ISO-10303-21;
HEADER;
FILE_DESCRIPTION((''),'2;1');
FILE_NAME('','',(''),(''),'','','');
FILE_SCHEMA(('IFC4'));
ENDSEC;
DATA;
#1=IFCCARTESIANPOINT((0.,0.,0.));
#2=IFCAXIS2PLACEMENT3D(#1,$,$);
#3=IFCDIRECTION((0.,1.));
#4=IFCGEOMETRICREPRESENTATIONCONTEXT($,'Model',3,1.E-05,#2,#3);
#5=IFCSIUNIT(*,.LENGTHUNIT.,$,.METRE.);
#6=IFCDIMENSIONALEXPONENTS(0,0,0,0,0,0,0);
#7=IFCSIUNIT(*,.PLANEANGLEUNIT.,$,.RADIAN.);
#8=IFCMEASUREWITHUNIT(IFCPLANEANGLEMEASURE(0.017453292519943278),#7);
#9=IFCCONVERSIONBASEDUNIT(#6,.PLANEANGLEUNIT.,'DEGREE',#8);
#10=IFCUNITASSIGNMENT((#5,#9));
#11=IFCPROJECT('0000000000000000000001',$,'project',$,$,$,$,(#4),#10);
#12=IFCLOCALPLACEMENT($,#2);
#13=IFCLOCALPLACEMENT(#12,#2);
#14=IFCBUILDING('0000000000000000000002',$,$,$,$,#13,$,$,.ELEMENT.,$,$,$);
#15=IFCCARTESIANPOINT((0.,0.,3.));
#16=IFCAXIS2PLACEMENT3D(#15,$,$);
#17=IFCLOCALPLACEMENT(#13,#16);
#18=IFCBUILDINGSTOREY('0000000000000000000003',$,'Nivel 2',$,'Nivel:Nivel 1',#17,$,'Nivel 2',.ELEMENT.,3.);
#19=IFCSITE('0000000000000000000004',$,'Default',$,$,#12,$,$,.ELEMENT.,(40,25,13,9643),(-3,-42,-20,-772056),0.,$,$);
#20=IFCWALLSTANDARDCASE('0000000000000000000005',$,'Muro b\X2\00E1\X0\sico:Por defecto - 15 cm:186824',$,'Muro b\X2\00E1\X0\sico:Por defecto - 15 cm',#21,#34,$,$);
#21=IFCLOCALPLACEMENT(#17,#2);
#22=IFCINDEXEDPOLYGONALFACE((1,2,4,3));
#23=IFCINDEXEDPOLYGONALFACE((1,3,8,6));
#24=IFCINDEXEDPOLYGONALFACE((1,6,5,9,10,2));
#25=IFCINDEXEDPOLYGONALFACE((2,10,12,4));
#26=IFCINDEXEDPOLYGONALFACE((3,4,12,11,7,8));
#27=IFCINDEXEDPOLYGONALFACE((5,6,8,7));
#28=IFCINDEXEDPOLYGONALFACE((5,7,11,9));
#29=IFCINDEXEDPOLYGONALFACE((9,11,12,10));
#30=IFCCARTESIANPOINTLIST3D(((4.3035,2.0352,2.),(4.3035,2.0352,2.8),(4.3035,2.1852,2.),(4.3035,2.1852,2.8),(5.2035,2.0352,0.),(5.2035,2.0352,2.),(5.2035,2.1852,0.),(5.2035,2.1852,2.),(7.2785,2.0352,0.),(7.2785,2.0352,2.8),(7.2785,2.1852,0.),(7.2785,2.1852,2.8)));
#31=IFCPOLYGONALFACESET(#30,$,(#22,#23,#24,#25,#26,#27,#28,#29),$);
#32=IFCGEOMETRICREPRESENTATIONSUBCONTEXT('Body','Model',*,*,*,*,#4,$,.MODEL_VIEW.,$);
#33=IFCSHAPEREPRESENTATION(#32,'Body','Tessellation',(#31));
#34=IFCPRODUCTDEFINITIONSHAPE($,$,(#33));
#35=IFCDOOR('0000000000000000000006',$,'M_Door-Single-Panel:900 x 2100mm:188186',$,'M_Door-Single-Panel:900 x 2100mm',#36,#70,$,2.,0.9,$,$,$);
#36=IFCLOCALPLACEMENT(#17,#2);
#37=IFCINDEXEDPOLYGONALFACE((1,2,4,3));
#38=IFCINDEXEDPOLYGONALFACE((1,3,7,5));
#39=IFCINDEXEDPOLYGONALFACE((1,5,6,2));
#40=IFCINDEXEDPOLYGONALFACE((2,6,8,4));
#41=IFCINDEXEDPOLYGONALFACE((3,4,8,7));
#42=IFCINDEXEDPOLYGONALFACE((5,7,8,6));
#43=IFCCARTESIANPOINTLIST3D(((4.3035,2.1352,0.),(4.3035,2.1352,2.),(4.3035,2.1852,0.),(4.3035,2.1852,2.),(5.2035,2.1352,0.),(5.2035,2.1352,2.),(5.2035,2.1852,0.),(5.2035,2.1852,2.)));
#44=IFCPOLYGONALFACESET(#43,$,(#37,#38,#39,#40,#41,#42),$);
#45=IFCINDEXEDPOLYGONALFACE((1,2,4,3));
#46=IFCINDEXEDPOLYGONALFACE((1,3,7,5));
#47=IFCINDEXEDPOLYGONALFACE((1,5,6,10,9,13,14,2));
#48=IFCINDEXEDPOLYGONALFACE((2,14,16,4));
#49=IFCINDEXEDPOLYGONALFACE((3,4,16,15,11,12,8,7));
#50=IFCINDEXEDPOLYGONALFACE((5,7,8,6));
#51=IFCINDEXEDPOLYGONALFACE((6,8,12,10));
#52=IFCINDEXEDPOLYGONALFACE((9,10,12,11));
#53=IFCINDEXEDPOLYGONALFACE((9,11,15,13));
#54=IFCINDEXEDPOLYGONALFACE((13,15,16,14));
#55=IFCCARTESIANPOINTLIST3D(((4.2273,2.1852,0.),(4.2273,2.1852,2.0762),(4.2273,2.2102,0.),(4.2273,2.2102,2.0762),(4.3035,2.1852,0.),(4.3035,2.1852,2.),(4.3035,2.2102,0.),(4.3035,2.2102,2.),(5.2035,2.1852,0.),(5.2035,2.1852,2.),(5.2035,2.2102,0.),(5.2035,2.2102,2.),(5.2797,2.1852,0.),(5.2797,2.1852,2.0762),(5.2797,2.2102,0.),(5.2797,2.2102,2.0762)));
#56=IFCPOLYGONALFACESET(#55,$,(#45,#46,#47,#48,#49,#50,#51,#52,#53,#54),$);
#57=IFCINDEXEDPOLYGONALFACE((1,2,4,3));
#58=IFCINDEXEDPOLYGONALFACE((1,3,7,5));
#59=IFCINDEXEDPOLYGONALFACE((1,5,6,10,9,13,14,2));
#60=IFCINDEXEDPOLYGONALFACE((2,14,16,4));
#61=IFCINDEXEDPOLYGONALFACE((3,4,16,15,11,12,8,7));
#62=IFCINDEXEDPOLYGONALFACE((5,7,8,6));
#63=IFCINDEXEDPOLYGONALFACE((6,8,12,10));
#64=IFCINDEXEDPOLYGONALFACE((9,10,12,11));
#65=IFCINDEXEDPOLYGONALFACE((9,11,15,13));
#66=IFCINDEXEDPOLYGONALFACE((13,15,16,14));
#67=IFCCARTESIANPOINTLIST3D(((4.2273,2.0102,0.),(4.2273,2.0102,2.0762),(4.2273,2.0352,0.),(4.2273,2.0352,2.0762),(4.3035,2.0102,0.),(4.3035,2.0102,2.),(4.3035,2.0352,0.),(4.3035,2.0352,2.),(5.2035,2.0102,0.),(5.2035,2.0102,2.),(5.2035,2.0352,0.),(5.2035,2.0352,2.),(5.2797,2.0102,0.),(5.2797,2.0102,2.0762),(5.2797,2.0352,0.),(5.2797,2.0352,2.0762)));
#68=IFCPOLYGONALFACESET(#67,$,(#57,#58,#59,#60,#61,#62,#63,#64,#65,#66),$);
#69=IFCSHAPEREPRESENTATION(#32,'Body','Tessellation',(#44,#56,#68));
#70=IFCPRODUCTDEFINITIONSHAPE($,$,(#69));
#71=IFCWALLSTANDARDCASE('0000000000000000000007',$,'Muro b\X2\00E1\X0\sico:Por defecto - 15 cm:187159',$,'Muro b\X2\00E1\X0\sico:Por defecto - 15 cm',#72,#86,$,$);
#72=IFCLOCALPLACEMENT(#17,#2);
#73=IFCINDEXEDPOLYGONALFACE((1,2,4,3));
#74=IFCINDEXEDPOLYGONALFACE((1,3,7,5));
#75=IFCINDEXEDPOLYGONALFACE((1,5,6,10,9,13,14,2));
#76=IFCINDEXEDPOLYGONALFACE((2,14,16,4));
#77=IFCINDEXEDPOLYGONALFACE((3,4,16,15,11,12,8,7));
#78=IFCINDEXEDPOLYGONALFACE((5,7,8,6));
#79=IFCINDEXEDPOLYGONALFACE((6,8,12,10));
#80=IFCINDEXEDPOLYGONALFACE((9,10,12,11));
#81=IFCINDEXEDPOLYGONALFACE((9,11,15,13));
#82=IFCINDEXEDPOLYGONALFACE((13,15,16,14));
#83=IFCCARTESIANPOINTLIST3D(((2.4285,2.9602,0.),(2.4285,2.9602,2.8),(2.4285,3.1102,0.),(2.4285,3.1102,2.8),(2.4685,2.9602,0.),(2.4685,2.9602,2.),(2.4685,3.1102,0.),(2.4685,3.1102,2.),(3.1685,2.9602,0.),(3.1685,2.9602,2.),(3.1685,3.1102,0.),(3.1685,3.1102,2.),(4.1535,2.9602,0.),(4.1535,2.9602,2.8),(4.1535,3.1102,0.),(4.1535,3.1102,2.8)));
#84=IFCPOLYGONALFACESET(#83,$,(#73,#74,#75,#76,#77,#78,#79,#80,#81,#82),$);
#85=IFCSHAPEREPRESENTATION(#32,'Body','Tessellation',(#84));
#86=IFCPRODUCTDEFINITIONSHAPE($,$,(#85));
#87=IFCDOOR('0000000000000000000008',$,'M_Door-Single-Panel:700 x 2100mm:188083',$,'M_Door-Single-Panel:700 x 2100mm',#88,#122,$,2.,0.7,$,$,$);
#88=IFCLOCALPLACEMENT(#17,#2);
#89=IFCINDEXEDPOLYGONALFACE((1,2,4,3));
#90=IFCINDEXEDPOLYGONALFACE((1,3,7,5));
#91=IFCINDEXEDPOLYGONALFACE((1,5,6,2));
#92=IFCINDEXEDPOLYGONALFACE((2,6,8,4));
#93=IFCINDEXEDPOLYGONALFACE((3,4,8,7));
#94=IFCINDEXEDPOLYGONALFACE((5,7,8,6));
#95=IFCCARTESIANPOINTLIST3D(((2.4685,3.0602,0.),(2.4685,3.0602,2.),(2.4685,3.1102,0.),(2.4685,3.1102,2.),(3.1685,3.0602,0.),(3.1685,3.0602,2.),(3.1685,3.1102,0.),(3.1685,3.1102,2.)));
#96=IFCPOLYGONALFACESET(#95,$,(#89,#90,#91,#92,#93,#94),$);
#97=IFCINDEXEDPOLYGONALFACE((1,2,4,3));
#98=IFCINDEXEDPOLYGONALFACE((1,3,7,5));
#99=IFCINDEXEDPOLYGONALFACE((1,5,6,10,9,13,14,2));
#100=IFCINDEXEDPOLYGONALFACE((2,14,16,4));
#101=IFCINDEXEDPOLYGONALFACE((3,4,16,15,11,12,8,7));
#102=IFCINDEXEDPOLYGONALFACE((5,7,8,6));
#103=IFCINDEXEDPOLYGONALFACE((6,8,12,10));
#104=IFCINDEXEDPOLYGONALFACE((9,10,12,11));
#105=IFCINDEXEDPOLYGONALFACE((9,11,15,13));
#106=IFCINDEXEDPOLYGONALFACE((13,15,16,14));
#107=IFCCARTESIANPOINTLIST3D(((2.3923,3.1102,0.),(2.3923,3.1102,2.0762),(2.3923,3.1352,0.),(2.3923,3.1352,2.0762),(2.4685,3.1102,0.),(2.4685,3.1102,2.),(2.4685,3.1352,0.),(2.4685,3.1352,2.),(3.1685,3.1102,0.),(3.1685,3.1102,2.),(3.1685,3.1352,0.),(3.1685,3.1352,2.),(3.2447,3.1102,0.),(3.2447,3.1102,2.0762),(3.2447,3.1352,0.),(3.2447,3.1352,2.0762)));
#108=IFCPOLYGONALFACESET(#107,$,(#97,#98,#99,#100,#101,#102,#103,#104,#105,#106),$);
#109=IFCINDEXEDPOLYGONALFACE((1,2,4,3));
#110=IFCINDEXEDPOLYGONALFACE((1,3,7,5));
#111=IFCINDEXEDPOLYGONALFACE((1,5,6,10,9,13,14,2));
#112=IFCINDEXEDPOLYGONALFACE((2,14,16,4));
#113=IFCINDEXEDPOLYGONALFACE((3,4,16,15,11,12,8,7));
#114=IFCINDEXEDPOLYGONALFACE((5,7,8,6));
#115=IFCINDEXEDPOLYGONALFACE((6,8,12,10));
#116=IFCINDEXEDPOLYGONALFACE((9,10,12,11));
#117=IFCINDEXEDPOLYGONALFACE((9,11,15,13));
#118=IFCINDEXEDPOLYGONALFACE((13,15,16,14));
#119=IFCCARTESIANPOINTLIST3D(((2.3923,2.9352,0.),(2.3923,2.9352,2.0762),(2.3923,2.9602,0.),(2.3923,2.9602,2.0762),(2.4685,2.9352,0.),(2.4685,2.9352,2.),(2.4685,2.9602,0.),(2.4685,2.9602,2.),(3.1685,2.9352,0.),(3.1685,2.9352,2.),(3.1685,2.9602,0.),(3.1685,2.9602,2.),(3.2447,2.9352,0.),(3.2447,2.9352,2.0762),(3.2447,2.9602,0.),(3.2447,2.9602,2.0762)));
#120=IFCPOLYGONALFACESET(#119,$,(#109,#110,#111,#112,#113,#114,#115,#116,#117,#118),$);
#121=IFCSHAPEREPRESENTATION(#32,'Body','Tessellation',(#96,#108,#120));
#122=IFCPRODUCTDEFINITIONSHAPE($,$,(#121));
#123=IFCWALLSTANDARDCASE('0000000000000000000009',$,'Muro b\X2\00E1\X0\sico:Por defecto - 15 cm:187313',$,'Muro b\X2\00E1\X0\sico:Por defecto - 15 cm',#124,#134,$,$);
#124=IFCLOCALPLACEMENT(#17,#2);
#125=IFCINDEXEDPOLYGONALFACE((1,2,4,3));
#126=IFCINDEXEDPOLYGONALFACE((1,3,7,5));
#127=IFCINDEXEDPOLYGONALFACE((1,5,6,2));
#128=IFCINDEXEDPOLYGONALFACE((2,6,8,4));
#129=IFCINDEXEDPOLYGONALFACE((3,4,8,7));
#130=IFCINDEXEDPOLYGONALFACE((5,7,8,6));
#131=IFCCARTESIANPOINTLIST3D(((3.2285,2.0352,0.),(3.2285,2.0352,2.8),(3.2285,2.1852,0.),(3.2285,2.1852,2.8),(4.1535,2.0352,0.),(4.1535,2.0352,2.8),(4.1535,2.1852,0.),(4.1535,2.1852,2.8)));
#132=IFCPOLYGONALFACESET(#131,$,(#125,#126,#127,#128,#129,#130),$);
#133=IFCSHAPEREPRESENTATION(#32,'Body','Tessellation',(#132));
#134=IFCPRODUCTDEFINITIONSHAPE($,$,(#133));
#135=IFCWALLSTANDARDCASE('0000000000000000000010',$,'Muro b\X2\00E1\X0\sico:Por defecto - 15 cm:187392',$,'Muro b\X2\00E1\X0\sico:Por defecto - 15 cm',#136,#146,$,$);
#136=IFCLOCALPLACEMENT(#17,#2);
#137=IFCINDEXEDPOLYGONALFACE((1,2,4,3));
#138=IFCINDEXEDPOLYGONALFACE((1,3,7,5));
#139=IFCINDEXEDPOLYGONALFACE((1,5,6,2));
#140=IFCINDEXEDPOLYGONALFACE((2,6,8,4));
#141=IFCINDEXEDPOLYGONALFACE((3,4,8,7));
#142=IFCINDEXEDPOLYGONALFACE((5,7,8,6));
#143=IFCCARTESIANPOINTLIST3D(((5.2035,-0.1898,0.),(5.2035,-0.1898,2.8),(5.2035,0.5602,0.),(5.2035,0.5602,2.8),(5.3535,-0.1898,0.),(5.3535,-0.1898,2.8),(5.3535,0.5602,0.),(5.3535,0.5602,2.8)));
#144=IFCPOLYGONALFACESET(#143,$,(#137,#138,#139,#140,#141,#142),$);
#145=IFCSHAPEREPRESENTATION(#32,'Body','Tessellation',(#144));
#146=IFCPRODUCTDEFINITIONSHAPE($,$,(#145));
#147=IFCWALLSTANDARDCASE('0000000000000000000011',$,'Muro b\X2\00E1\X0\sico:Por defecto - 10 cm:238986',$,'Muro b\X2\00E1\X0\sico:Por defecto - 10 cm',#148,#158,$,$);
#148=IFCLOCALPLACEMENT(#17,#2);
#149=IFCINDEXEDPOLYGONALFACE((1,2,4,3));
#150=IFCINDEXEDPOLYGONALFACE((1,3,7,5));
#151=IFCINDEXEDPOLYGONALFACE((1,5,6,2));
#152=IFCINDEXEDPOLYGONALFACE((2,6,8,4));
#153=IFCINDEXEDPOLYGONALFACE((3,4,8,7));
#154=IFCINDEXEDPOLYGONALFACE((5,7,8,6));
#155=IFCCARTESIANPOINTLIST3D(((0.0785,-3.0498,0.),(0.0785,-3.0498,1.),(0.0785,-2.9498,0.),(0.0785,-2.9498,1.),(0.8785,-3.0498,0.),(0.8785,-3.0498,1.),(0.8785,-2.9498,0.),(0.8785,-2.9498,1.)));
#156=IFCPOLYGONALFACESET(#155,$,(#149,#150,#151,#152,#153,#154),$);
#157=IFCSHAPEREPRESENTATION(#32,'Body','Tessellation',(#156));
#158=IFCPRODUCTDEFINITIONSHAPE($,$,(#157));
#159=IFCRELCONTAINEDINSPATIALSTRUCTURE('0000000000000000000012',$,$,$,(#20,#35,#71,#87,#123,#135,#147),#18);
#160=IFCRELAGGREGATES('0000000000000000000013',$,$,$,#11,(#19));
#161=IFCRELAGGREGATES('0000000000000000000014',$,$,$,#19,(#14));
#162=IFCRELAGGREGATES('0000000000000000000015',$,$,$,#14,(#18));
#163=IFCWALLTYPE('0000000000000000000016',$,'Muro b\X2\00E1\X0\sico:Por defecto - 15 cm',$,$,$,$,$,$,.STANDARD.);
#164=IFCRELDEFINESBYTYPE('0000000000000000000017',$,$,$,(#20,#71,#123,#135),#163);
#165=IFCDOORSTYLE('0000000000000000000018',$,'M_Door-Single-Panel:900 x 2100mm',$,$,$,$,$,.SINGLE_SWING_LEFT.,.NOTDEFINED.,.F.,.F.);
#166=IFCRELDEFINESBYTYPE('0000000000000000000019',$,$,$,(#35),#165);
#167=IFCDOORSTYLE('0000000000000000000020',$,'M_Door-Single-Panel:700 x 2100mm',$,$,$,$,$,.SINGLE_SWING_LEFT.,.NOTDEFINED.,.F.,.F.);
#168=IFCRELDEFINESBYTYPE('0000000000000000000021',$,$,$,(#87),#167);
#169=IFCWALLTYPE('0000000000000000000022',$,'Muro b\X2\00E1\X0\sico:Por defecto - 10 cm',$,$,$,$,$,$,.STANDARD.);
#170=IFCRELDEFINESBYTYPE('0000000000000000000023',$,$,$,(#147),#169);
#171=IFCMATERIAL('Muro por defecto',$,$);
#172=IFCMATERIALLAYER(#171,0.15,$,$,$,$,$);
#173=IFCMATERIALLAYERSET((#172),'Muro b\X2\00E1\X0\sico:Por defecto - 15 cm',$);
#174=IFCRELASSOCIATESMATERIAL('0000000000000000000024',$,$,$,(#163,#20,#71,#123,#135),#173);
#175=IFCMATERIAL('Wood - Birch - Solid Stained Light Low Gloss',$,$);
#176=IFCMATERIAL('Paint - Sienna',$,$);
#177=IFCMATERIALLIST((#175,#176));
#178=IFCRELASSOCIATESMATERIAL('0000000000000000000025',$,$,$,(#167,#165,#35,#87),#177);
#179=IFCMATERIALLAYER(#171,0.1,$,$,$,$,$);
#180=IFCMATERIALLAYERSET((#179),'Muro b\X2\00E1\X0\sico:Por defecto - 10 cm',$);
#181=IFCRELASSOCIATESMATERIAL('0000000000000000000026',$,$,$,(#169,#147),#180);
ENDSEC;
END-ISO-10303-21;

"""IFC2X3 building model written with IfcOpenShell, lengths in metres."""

from ifc_helpers import new_model, entity, si_unit, converted_unit, direction, frame, frame_2d, origin, origin_2d_with_axis, place, context, subcontext, project, spatial, polyline, rectangle, outline, extrude, clip, bounded_halfspace, source, transform, mapped, material, material_list, layer, layer_set, layer_usage, type_object, type_shapes, element, fill, save


model = new_model("IFC2X3")

# Units and contexts
model_context = context("Model", 3, precision=1e-05, world=origin(), true_north=direction((0.0, 1.0)))
body_context = subcontext(model_context, "Body", "Model", "MODEL_VIEW")
ifc_project = project(units=[si_unit("LENGTHUNIT", "METRE"), converted_unit("PLANEANGLEUNIT", "DEGREE", entity("IfcPlaneAngleMeasure", 0.017453292519943278), si_unit("PLANEANGLEUNIT", "RADIAN"), dimensions=[0, 0, 0, 0, 0, 0, 0])], contexts=[model_context])

# Site, building, storey
site_placement = place(None, origin())
site = spatial("IfcSite", under=ifc_project, at=site_placement, Name="Default", CompositionType="ELEMENT", RefLatitude=(40, 25, 13, 9643), RefLongitude=(-3, -42, -20, -772056), RefElevation=0.0)
building_placement = place(site_placement, origin())
building = spatial("IfcBuilding", under=site, at=building_placement, CompositionType="ELEMENT")
storey_placement = place(building_placement, frame((0.0, 0.0, 3.0)))
storey = spatial("IfcBuildingStorey", under=building, at=storey_placement, Name="Nivel 2", ObjectType="Nivel:Nivel 1", LongName="Nivel 2", CompositionType="ELEMENT", Elevation=3.0)

# Shared definitions
ifc_material_1 = material(Name="Muro por defecto")
ifc_layer_1 = layer(ifc_material_1, 0.15)
ifc_layer_set_1 = layer_set([ifc_layer_1], Name="Muro básico:Por defecto - 15 cm")
wall_type_1 = type_object("IfcWallType", Name="Muro básico:Por defecto - 15 cm", PredefinedType="STANDARD", material=ifc_layer_set_1)

# Shared definitions
ifc_material_2 = material(Name="Wood - Birch - Solid Stained Light Low Gloss")
ifc_material_3 = material(Name="Paint - Sienna")
ifc_material_list_1 = material_list([ifc_material_2, ifc_material_3])

# Shared definitions
door_style_1 = type_object("IfcDoorStyle", Name="M_Door-Single-Panel:700 x 2100mm", ConstructionType="NOTDEFINED", OperationType="SINGLE_SWING_LEFT", ParameterTakesPrecedence=False, Sizeable=False, material=ifc_material_list_1)
shared_shape_1 = source(origin(), body_context, "Body", "SweptSolid", [
    extrude(rectangle(XDim=0.7, YDim=0.05, at=origin_2d_with_axis()), frame((0.35, 0.125, 0.0)), (0.0, 0.0, 1.0), 2.0),
    extrude(outline(polyline([(-0.4262, -1.0571), (0.4262, -1.0571), (0.4262, 1.0191), (0.35, 1.0191), (0.35, -0.981), (-0.35, -0.981), (-0.35, 1.0191), (-0.4262, 1.0191), (-0.4262, -1.0571)])), frame((0.35, 0.175, 1.0191), z_axis=(0.0, -1.0, 0.0), x_axis=(-1.0, 0.0, 0.0)), (0.0, 0.0, 1.0), 0.025),
    extrude(outline(polyline([(-1.0571, -0.4262), (1.019, -0.4262), (1.019, -0.35), (-0.9809, -0.35), (-0.9809, 0.35), (1.019, 0.35), (1.019, 0.4262), (-1.0571, 0.4262), (-1.0571, -0.4262)])), frame((0.35, 0.0, 1.019), z_axis=(0.0, -1.0, 0.0), x_axis=(0.0, 0.0, -1.0)), (0.0, 0.0, 1.0), 0.025),
])
type_shapes(door_style_1, [shared_shape_1])

# Wall, opening, door
ifc_layer_usage_1 = layer_usage(ifc_layer_set_1, "AXIS2", "NEGATIVE", 0.075)
wall_1_placement = place(storey_placement, frame((7.2785, 2.1102, 0.0), z_axis=(0.0, 0.0, 1.0), x_axis=(-1.0, 0.0, 0.0)))
wall_1 = element("IfcWallStandardCase", 1, at=wall_1_placement, inside=storey, type_object=wall_type_1, material=ifc_layer_usage_1, Name="Muro básico:Por defecto - 15 cm:186824", ObjectType="Muro básico:Por defecto - 15 cm", context=body_context, shape_type="Clipping", body=[
    clip(extrude(rectangle(XDim=2.975, YDim=0.15, at=frame_2d((1.4875, 0.0), x_axis=(-1.0, 0.0))), origin(), (0.0, 0.0, 1.0), 2.8), bounded_halfspace(frame((0.0, -0.075, 2.8), z_axis=(0.0, 0.0, -1.0), x_axis=(-1.0, 0.0, 0.0)), True, frame((0.0, -0.075, 2.8)), polyline([(0.0, 0.0), (1.1382, 0.0), (1.2882, 0.0), (1.925, 0.0), (2.075, 0.0), (2.975, 0.0), (2.975, 0.15), (0.0, 0.15), (0.0, 0.0)]))),
])
opening_1_placement = place(wall_1_placement, frame((2.975, 0.075, 0.0)))
opening_1 = element("IfcOpeningElement", 2, at=opening_1_placement, cuts=wall_1, ObjectType="Opening", context=body_context, shape_type="SweptSolid", body=[
    extrude(rectangle(XDim=0.9, YDim=2.0, at=frame_2d((1.0, 0.45), x_axis=(0.0, -1.0))), frame((0.0, 0.0, 0.0), z_axis=(0.0, -1.0, 0.0), x_axis=(0.0, 0.0, 1.0)), (0.0, 0.0, 1.0), 0.15),
])
door_style_2 = type_object("IfcDoorStyle", Name="M_Door-Single-Panel:900 x 2100mm", ConstructionType="NOTDEFINED", OperationType="SINGLE_SWING_LEFT", ParameterTakesPrecedence=False, Sizeable=False, material=ifc_material_list_1)
shared_shape_2 = source(origin(), body_context, "Body", "SweptSolid", [
    extrude(rectangle(XDim=0.9, YDim=0.05, at=origin_2d_with_axis()), frame((0.45, 0.125, 0.0)), (0.0, 0.0, 1.0), 2.0),
    extrude(outline(polyline([(-0.5262, -1.0571), (0.5262, -1.0571), (0.5262, 1.0191), (0.45, 1.0191), (0.45, -0.981), (-0.45, -0.981), (-0.45, 1.0191), (-0.5262, 1.0191), (-0.5262, -1.0571)])), frame((0.45, 0.175, 1.0191), z_axis=(0.0, -1.0, 0.0), x_axis=(-1.0, 0.0, 0.0)), (0.0, 0.0, 1.0), 0.025),
    extrude(outline(polyline([(-1.0571, -0.5262), (1.019, -0.5262), (1.019, -0.45), (-0.9809, -0.45), (-0.9809, 0.45), (1.019, 0.45), (1.019, 0.5262), (-1.0571, 0.5262), (-1.0571, -0.5262)])), frame((0.45, 0.0, 1.019), z_axis=(0.0, -1.0, 0.0), x_axis=(0.0, 0.0, -1.0)), (0.0, 0.0, 1.0), 0.025),
])
type_shapes(door_style_2, [shared_shape_2])
door_1_placement = place(opening_1_placement, frame((0.0, 0.0, 0.0), z_axis=(0.0, 0.0, 1.0), x_axis=(-1.0, 0.0, 0.0)))
door_1 = element("IfcDoor", 3, at=door_1_placement, inside=storey, type_object=door_style_2, material=ifc_material_list_1, Name="M_Door-Single-Panel:900 x 2100mm:188186", ObjectType="M_Door-Single-Panel:900 x 2100mm", OverallHeight=2.0, OverallWidth=0.9, context=body_context, shape_type="MappedRepresentation", body=[
    mapped(shared_shape_2, transform((0.0, 0.0, 0.0), scale=1.0)),
])
fill(opening_1, door_1)

# Wall, opening, door
ifc_layer_usage_2 = layer_usage(ifc_layer_set_1, "AXIS2", "NEGATIVE", 0.075)
wall_2_placement = place(storey_placement, frame((4.1535, 3.0352, 0.0), z_axis=(0.0, 0.0, 1.0), x_axis=(-1.0, 0.0, 0.0)))
wall_2 = element("IfcWallStandardCase", 4, at=wall_2_placement, inside=storey, type_object=wall_type_1, material=ifc_layer_usage_2, Name="Muro básico:Por defecto - 15 cm:187159", ObjectType="Muro básico:Por defecto - 15 cm", context=body_context, shape_type="Clipping", body=[
    clip(extrude(rectangle(XDim=1.725, YDim=0.15, at=frame_2d((0.8625, 0.0), x_axis=(1.0, 0.0))), origin(), (0.0, 0.0, 1.0), 2.8), bounded_halfspace(frame((0.0, -0.075, 2.8), z_axis=(0.0, 0.0, -1.0), x_axis=(-1.0, 0.0, 0.0)), True, frame((0.0, -0.075, 2.8)), polyline([(0.0, 0.0), (1.725, 0.0), (1.725, 0.15), (0.0, 0.15), (0.0, 0.0)]))),
])
opening_2_placement = place(wall_2_placement, frame((1.685, 0.075, 0.0)))
opening_2 = element("IfcOpeningElement", 5, at=opening_2_placement, cuts=wall_2, ObjectType="Opening", context=body_context, shape_type="SweptSolid", body=[
    extrude(rectangle(XDim=0.7, YDim=2.0, at=frame_2d((1.0, 0.35), x_axis=(0.0, -1.0))), frame((0.0, 0.0, 0.0), z_axis=(0.0, -1.0, 0.0), x_axis=(0.0, 0.0, 1.0)), (0.0, 0.0, 1.0), 0.15),
])
door_2_placement = place(opening_2_placement, frame((0.0, 0.0, 0.0), z_axis=(0.0, 0.0, 1.0), x_axis=(-1.0, 0.0, 0.0)))
door_2 = element("IfcDoor", 6, at=door_2_placement, inside=storey, type_object=door_style_1, material=ifc_material_list_1, Name="M_Door-Single-Panel:700 x 2100mm:188083", ObjectType="M_Door-Single-Panel:700 x 2100mm", OverallHeight=2.0, OverallWidth=0.7, context=body_context, shape_type="MappedRepresentation", body=[
    mapped(shared_shape_1, transform((0.0, 0.0, 0.0), scale=1.0)),
])
fill(opening_2, door_2)

# Walls
ifc_layer_usage_3 = layer_usage(ifc_layer_set_1, "AXIS2", "NEGATIVE", 0.075)
wall_3_placement = place(storey_placement, frame((4.1535, 2.1102, 0.0), z_axis=(0.0, 0.0, 1.0), x_axis=(-1.0, 0.0, 0.0)))
element("IfcWallStandardCase", 7, at=wall_3_placement, inside=storey, type_object=wall_type_1, material=ifc_layer_usage_3, Name="Muro básico:Por defecto - 15 cm:187313", ObjectType="Muro básico:Por defecto - 15 cm", context=body_context, shape_type="Clipping", body=[
    clip(extrude(rectangle(XDim=0.925, YDim=0.15, at=frame_2d((0.4625, 0.0), x_axis=(-1.0, 0.0))), origin(), (0.0, 0.0, 1.0), 2.8), bounded_halfspace(frame((0.0, -0.075, 2.8), z_axis=(0.0, 0.0, -1.0), x_axis=(-1.0, 0.0, 0.0)), True, frame((0.0, -0.075, 2.8)), polyline([(0.0, 0.0), (0.925, 0.0), (0.925, 0.15), (0.0, 0.15), (0.0, 0.0)]))),
])
ifc_layer_usage_4 = layer_usage(ifc_layer_set_1, "AXIS2", "NEGATIVE", 0.075)
wall_4_placement = place(storey_placement, frame((5.2785, -0.1898, 0.0), z_axis=(0.0, 0.0, 1.0), x_axis=(0.0, 1.0, 0.0)))
element("IfcWallStandardCase", 8, at=wall_4_placement, inside=storey, type_object=wall_type_1, material=ifc_layer_usage_4, Name="Muro básico:Por defecto - 15 cm:187392", ObjectType="Muro básico:Por defecto - 15 cm", context=body_context, shape_type="Clipping", body=[
    clip(extrude(rectangle(XDim=0.75, YDim=0.15, at=frame_2d((0.375, 0.0), x_axis=(-1.0, 0.0))), origin(), (0.0, 0.0, 1.0), 2.8), bounded_halfspace(frame((0.0, -0.075, 2.8), z_axis=(0.0, 0.0, -1.0), x_axis=(0.0, -1.0, 0.0)), True, frame((0.0, -0.075, 2.8)), polyline([(0.0, 0.0), (0.75, 0.0), (0.75, 0.15), (0.0, 0.15), (0.0, 0.0)]))),
])
ifc_layer_2 = layer(ifc_material_1, 0.1)
ifc_layer_set_2 = layer_set([ifc_layer_2], Name="Muro básico:Por defecto - 10 cm")
ifc_layer_usage_5 = layer_usage(ifc_layer_set_2, "AXIS2", "POSITIVE", -0.05)
wall_type_2 = type_object("IfcWallType", Name="Muro básico:Por defecto - 10 cm", PredefinedType="STANDARD", material=ifc_layer_set_2)
wall_5_placement = place(storey_placement, frame((0.0785, -2.9998, 0.0)))
element("IfcWallStandardCase", 9, at=wall_5_placement, inside=storey, type_object=wall_type_2, material=ifc_layer_usage_5, Name="Muro básico:Por defecto - 10 cm:238986", ObjectType="Muro básico:Por defecto - 10 cm", context=body_context, shape_type="SweptSolid", body=[
    extrude(rectangle(XDim=0.8, YDim=0.1, at=frame_2d((0.4, 0.0), x_axis=(-1.0, 0.0))), origin(), (0.0, 0.0, 1.0), 1.0),
])

save(model, "model.ifc")
